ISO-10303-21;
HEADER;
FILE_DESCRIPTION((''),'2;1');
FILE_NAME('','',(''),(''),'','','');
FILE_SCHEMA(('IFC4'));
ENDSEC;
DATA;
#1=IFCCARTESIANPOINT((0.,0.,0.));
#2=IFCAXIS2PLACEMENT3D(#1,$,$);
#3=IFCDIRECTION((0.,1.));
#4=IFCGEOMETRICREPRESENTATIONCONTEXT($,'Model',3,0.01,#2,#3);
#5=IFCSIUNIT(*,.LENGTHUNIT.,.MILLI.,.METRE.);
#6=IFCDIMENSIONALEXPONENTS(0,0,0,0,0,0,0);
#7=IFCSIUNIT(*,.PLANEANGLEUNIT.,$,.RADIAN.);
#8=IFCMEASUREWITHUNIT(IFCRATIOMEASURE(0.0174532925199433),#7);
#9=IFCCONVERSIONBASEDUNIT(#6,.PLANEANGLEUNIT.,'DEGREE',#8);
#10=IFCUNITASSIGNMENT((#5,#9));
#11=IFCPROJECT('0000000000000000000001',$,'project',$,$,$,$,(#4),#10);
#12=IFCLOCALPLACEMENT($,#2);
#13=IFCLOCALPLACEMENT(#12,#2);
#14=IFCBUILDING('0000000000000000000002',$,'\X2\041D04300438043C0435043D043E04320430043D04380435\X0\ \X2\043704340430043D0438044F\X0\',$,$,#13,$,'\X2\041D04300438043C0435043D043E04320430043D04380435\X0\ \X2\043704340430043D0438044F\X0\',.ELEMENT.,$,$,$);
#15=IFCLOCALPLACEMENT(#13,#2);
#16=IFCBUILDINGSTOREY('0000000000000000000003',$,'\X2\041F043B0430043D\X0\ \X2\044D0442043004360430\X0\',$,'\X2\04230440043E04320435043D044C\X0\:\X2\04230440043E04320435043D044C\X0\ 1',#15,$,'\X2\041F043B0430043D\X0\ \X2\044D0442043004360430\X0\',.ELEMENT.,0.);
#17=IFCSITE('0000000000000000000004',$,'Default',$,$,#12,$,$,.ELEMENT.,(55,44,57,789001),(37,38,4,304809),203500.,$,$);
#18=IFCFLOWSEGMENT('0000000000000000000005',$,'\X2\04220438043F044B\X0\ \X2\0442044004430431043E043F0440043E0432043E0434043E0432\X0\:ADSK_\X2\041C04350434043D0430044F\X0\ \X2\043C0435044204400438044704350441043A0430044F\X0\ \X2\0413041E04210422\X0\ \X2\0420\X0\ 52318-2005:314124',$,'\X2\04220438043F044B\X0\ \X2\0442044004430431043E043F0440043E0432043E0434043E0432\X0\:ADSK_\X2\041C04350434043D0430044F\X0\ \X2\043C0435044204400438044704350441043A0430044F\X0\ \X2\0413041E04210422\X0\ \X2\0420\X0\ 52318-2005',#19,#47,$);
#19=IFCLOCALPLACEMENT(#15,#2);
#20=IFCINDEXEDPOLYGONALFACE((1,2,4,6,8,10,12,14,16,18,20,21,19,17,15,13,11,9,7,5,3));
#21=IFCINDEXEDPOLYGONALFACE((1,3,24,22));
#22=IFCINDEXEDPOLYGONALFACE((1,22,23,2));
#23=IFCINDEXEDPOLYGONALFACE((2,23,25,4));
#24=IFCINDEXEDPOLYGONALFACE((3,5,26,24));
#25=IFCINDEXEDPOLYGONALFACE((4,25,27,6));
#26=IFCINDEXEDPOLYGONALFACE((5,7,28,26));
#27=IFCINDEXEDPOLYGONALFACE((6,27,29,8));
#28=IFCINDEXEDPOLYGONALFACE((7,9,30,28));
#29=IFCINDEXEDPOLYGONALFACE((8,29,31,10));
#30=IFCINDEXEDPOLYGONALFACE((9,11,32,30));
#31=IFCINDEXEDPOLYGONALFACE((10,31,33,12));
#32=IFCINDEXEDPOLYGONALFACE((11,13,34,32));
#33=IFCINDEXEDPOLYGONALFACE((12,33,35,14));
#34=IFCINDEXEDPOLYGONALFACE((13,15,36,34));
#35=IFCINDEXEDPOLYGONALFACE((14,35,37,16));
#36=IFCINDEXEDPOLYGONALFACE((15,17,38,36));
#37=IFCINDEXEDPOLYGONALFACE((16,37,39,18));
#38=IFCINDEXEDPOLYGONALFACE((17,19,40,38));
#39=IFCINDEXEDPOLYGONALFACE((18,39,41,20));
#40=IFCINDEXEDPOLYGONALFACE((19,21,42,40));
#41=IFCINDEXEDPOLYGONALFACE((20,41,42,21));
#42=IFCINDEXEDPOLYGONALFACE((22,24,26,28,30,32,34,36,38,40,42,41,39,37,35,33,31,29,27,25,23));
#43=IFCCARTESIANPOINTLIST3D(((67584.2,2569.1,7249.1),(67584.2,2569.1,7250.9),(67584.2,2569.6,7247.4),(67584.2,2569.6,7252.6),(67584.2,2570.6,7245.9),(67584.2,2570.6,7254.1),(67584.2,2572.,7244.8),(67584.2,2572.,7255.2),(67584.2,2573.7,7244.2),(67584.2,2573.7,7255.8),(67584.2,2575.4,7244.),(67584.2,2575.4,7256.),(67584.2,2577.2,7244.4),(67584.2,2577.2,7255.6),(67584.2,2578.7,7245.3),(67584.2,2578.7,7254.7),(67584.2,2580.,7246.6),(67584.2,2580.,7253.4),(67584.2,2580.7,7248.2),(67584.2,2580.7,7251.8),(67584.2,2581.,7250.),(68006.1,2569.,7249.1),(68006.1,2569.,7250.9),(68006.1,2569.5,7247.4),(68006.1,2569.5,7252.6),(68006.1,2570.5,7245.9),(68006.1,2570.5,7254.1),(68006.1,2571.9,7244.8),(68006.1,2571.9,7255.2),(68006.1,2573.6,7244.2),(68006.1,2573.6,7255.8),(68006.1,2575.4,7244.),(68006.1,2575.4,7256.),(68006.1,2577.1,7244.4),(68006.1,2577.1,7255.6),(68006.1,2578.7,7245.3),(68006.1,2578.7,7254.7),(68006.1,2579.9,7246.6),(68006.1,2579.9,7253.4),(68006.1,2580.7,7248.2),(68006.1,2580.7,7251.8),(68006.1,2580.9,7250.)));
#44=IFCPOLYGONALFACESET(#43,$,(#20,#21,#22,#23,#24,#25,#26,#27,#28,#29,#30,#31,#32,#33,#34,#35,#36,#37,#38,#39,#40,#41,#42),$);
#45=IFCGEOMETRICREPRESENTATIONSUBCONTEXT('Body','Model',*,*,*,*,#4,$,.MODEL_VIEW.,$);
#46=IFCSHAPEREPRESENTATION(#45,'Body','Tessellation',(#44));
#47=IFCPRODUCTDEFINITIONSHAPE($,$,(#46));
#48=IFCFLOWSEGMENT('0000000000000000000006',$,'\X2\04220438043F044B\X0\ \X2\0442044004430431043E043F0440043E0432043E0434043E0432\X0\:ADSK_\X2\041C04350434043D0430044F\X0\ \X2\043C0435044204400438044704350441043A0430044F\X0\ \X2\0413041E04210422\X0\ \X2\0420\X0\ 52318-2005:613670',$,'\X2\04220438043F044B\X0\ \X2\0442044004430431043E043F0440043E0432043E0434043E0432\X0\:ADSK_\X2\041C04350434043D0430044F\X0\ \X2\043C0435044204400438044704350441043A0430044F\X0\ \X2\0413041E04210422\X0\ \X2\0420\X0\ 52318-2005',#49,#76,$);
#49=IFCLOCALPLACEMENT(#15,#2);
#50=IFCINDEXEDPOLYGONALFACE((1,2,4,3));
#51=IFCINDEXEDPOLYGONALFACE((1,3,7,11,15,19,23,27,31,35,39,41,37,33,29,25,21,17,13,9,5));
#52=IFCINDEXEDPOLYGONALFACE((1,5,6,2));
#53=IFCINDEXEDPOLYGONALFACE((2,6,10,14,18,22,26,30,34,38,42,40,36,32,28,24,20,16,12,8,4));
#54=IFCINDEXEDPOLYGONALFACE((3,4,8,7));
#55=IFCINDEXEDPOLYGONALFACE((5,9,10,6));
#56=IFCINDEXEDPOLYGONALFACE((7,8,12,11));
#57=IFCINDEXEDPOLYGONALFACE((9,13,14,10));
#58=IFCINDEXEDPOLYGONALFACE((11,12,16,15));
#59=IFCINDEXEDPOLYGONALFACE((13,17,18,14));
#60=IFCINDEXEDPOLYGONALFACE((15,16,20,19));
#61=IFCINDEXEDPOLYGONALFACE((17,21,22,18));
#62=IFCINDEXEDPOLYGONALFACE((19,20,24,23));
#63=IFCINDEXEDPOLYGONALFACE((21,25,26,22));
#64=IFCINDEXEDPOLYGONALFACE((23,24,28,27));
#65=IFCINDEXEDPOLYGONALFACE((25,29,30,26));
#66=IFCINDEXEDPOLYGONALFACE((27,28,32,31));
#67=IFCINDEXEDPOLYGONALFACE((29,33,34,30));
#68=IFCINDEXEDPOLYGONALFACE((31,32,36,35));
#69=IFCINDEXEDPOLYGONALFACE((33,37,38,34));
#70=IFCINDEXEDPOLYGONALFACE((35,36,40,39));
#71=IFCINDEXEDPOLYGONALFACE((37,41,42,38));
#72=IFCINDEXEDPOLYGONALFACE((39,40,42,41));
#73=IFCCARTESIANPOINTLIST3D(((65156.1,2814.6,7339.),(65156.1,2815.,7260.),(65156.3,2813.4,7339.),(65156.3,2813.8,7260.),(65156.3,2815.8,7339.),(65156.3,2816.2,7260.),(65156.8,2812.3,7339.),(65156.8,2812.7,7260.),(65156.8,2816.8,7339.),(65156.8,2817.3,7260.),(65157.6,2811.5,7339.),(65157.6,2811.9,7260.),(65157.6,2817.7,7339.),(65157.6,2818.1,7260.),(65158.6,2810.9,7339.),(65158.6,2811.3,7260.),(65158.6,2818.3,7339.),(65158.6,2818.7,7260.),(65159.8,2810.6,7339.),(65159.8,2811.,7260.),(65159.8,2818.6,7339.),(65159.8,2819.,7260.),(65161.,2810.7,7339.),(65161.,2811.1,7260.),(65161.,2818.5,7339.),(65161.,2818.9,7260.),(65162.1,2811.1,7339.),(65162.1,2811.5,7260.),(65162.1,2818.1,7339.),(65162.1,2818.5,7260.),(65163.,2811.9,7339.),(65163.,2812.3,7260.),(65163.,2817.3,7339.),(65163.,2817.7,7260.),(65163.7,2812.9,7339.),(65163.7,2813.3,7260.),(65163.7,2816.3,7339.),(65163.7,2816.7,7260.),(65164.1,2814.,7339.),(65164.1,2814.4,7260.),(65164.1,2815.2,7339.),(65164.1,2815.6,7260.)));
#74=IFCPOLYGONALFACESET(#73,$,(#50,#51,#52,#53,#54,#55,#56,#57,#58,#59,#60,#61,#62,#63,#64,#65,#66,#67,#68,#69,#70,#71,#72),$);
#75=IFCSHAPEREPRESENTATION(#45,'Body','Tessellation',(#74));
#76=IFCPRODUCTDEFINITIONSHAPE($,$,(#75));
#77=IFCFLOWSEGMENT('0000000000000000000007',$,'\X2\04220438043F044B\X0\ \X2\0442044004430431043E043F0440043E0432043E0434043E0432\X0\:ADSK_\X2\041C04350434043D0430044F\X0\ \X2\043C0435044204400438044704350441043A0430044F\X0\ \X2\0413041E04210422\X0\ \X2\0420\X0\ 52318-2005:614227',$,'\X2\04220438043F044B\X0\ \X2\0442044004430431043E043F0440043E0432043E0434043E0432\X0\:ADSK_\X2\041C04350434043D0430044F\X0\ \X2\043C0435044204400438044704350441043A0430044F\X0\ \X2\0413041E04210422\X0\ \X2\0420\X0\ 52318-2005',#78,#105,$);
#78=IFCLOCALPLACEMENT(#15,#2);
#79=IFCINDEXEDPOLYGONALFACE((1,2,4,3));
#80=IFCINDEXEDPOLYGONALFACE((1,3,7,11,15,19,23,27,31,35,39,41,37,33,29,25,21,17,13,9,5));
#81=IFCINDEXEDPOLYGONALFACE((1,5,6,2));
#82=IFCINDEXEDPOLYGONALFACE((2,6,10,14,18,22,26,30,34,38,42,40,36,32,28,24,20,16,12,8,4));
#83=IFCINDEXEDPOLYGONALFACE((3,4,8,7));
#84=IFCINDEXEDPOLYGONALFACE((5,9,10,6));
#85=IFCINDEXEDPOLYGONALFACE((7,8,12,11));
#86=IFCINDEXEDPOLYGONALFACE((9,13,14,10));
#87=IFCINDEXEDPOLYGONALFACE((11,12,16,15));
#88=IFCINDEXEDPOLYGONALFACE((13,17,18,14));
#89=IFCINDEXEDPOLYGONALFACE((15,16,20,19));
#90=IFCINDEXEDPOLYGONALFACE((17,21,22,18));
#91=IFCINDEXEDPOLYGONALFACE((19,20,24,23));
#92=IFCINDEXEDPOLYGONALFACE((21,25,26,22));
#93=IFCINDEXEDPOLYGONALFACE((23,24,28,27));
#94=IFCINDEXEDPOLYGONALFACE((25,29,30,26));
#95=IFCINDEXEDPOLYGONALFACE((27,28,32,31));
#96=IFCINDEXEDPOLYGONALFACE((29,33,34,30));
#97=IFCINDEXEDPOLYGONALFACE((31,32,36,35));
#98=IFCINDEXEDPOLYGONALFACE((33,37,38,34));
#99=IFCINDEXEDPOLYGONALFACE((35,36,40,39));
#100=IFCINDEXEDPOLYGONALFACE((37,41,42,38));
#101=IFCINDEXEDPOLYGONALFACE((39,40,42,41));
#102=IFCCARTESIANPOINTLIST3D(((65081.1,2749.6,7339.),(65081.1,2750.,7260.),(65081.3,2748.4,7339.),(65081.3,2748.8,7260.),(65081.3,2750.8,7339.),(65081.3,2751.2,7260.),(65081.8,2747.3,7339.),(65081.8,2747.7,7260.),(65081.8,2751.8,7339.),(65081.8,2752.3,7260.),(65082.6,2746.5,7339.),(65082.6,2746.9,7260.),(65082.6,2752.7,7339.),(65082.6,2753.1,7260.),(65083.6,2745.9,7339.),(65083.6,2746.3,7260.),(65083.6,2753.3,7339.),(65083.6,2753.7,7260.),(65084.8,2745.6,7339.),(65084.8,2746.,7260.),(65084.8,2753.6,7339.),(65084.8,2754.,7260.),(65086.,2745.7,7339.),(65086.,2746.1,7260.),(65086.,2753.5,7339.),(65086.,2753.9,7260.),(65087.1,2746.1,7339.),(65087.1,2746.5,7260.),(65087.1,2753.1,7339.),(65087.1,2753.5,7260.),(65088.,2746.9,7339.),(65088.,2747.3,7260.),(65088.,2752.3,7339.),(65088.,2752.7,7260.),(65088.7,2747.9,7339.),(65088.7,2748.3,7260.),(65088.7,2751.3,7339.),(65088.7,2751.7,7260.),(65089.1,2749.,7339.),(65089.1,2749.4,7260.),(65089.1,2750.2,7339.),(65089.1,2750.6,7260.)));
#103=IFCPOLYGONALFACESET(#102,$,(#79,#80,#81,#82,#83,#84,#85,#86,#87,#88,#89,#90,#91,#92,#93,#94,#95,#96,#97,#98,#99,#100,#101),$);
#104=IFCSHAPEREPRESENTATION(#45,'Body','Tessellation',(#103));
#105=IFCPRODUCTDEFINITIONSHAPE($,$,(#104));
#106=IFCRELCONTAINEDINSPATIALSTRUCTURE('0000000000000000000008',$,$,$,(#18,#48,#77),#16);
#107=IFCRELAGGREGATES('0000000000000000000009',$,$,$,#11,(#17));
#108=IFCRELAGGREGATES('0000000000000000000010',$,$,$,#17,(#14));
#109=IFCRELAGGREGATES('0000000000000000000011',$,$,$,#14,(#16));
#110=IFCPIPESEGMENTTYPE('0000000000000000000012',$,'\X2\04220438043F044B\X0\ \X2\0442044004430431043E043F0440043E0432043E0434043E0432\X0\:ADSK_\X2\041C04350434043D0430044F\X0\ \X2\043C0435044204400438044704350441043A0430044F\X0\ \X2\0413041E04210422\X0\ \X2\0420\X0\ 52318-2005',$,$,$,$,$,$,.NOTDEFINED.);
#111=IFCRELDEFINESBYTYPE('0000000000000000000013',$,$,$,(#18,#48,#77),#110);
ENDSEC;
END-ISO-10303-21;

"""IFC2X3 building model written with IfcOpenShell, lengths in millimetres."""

from ifc_helpers import new_model, entity, si_unit, converted_unit, direction, frame, frame_2d, origin, origin_2d_with_axis, place, context, subcontext, project, spatial, circle, extrude, type_object, element, save


model = new_model("IFC2X3")

# Units and contexts
model_context = context("Model", 3, precision=0.01, world=origin(), true_north=direction((0.0, 1.0)))
body_context = subcontext(model_context, "Body", "Model", "MODEL_VIEW")
ifc_project = project(units=[si_unit("LENGTHUNIT", "METRE", prefix="MILLI"), converted_unit("PLANEANGLEUNIT", "DEGREE", entity("IfcRatioMeasure", 0.0174532925199433), si_unit("PLANEANGLEUNIT", "RADIAN"), dimensions=[0, 0, 0, 0, 0, 0, 0])], contexts=[model_context])

# Site, building, storey
site_placement = place(None, frame((0.0, 0.0, 0.0)))
site = spatial("IfcSite", under=ifc_project, at=site_placement, Name="Default", CompositionType="ELEMENT", RefLatitude=(55, 44, 57, 789001), RefLongitude=(37, 38, 4, 304809), RefElevation=203500.0)
building_placement = place(site_placement, origin())
building = spatial("IfcBuilding", under=site, at=building_placement, Name="Наименование здания", LongName="Наименование здания", CompositionType="ELEMENT")
storey_placement = place(building_placement, origin())
storey = spatial("IfcBuildingStorey", under=building, at=storey_placement, Name="План этажа", ObjectType="Уровень:Уровень 1", LongName="План этажа", CompositionType="ELEMENT", Elevation=0.0)

# Flow segments
pipe_segment_type = type_object("IfcPipeSegmentType", Name="Типы трубопроводов:ADSK_Медная метрическая ГОСТ Р 52318-2005", PredefinedType="NOTDEFINED")
flow_segment_1_placement = place(storey_placement, frame((67584.2, 2567.3, 7242.4)))
element("IfcFlowSegment", 1, at=flow_segment_1_placement, inside=storey, type_object=pipe_segment_type, Name="Типы трубопроводов:ADSK_Медная метрическая ГОСТ Р 52318-2005:314124", ObjectType="Типы трубопроводов:ADSK_Медная метрическая ГОСТ Р 52318-2005", context=body_context, shape_type="SweptSolid", body=[
    extrude(circle(Radius=6.0, at=frame_2d((0.0, 0.0), x_axis=(1.0, 0.0))), frame((0.0, 7.7, 7.6), z_axis=(1.0, -0.000145, 0.0), x_axis=(0.000145, 1.0, 0.0)), (0.0, 0.0, 1.0), 421.9),
])
for number, where, name in (
    (2, (65154.5, 2809.0, 7260.0), "Типы трубопроводов:ADSK_Медная метрическая ГОСТ Р 52318-2005:613670"),
    (3, (65079.5, 2744.0, 7260.0), "Типы трубопроводов:ADSK_Медная метрическая ГОСТ Р 52318-2005:614227"),
):
    element("IfcFlowSegment", number, at=place(storey_placement, frame(where)), inside=storey, type_object=pipe_segment_type, Name=name, ObjectType="Типы трубопроводов:ADSK_Медная метрическая ГОСТ Р 52318-2005", context=body_context, shape_type="SweptSolid", body=[
        extrude(circle(Radius=4.0, at=origin_2d_with_axis()), frame((5.6, 5.6, 79.0), z_axis=(0.0, 0.005247, -0.999986), x_axis=(-1.0, 0.0, 0.0)), (0.0, 0.0, 1.0), 79.0),
    ])

save(model, "model.ifc")
